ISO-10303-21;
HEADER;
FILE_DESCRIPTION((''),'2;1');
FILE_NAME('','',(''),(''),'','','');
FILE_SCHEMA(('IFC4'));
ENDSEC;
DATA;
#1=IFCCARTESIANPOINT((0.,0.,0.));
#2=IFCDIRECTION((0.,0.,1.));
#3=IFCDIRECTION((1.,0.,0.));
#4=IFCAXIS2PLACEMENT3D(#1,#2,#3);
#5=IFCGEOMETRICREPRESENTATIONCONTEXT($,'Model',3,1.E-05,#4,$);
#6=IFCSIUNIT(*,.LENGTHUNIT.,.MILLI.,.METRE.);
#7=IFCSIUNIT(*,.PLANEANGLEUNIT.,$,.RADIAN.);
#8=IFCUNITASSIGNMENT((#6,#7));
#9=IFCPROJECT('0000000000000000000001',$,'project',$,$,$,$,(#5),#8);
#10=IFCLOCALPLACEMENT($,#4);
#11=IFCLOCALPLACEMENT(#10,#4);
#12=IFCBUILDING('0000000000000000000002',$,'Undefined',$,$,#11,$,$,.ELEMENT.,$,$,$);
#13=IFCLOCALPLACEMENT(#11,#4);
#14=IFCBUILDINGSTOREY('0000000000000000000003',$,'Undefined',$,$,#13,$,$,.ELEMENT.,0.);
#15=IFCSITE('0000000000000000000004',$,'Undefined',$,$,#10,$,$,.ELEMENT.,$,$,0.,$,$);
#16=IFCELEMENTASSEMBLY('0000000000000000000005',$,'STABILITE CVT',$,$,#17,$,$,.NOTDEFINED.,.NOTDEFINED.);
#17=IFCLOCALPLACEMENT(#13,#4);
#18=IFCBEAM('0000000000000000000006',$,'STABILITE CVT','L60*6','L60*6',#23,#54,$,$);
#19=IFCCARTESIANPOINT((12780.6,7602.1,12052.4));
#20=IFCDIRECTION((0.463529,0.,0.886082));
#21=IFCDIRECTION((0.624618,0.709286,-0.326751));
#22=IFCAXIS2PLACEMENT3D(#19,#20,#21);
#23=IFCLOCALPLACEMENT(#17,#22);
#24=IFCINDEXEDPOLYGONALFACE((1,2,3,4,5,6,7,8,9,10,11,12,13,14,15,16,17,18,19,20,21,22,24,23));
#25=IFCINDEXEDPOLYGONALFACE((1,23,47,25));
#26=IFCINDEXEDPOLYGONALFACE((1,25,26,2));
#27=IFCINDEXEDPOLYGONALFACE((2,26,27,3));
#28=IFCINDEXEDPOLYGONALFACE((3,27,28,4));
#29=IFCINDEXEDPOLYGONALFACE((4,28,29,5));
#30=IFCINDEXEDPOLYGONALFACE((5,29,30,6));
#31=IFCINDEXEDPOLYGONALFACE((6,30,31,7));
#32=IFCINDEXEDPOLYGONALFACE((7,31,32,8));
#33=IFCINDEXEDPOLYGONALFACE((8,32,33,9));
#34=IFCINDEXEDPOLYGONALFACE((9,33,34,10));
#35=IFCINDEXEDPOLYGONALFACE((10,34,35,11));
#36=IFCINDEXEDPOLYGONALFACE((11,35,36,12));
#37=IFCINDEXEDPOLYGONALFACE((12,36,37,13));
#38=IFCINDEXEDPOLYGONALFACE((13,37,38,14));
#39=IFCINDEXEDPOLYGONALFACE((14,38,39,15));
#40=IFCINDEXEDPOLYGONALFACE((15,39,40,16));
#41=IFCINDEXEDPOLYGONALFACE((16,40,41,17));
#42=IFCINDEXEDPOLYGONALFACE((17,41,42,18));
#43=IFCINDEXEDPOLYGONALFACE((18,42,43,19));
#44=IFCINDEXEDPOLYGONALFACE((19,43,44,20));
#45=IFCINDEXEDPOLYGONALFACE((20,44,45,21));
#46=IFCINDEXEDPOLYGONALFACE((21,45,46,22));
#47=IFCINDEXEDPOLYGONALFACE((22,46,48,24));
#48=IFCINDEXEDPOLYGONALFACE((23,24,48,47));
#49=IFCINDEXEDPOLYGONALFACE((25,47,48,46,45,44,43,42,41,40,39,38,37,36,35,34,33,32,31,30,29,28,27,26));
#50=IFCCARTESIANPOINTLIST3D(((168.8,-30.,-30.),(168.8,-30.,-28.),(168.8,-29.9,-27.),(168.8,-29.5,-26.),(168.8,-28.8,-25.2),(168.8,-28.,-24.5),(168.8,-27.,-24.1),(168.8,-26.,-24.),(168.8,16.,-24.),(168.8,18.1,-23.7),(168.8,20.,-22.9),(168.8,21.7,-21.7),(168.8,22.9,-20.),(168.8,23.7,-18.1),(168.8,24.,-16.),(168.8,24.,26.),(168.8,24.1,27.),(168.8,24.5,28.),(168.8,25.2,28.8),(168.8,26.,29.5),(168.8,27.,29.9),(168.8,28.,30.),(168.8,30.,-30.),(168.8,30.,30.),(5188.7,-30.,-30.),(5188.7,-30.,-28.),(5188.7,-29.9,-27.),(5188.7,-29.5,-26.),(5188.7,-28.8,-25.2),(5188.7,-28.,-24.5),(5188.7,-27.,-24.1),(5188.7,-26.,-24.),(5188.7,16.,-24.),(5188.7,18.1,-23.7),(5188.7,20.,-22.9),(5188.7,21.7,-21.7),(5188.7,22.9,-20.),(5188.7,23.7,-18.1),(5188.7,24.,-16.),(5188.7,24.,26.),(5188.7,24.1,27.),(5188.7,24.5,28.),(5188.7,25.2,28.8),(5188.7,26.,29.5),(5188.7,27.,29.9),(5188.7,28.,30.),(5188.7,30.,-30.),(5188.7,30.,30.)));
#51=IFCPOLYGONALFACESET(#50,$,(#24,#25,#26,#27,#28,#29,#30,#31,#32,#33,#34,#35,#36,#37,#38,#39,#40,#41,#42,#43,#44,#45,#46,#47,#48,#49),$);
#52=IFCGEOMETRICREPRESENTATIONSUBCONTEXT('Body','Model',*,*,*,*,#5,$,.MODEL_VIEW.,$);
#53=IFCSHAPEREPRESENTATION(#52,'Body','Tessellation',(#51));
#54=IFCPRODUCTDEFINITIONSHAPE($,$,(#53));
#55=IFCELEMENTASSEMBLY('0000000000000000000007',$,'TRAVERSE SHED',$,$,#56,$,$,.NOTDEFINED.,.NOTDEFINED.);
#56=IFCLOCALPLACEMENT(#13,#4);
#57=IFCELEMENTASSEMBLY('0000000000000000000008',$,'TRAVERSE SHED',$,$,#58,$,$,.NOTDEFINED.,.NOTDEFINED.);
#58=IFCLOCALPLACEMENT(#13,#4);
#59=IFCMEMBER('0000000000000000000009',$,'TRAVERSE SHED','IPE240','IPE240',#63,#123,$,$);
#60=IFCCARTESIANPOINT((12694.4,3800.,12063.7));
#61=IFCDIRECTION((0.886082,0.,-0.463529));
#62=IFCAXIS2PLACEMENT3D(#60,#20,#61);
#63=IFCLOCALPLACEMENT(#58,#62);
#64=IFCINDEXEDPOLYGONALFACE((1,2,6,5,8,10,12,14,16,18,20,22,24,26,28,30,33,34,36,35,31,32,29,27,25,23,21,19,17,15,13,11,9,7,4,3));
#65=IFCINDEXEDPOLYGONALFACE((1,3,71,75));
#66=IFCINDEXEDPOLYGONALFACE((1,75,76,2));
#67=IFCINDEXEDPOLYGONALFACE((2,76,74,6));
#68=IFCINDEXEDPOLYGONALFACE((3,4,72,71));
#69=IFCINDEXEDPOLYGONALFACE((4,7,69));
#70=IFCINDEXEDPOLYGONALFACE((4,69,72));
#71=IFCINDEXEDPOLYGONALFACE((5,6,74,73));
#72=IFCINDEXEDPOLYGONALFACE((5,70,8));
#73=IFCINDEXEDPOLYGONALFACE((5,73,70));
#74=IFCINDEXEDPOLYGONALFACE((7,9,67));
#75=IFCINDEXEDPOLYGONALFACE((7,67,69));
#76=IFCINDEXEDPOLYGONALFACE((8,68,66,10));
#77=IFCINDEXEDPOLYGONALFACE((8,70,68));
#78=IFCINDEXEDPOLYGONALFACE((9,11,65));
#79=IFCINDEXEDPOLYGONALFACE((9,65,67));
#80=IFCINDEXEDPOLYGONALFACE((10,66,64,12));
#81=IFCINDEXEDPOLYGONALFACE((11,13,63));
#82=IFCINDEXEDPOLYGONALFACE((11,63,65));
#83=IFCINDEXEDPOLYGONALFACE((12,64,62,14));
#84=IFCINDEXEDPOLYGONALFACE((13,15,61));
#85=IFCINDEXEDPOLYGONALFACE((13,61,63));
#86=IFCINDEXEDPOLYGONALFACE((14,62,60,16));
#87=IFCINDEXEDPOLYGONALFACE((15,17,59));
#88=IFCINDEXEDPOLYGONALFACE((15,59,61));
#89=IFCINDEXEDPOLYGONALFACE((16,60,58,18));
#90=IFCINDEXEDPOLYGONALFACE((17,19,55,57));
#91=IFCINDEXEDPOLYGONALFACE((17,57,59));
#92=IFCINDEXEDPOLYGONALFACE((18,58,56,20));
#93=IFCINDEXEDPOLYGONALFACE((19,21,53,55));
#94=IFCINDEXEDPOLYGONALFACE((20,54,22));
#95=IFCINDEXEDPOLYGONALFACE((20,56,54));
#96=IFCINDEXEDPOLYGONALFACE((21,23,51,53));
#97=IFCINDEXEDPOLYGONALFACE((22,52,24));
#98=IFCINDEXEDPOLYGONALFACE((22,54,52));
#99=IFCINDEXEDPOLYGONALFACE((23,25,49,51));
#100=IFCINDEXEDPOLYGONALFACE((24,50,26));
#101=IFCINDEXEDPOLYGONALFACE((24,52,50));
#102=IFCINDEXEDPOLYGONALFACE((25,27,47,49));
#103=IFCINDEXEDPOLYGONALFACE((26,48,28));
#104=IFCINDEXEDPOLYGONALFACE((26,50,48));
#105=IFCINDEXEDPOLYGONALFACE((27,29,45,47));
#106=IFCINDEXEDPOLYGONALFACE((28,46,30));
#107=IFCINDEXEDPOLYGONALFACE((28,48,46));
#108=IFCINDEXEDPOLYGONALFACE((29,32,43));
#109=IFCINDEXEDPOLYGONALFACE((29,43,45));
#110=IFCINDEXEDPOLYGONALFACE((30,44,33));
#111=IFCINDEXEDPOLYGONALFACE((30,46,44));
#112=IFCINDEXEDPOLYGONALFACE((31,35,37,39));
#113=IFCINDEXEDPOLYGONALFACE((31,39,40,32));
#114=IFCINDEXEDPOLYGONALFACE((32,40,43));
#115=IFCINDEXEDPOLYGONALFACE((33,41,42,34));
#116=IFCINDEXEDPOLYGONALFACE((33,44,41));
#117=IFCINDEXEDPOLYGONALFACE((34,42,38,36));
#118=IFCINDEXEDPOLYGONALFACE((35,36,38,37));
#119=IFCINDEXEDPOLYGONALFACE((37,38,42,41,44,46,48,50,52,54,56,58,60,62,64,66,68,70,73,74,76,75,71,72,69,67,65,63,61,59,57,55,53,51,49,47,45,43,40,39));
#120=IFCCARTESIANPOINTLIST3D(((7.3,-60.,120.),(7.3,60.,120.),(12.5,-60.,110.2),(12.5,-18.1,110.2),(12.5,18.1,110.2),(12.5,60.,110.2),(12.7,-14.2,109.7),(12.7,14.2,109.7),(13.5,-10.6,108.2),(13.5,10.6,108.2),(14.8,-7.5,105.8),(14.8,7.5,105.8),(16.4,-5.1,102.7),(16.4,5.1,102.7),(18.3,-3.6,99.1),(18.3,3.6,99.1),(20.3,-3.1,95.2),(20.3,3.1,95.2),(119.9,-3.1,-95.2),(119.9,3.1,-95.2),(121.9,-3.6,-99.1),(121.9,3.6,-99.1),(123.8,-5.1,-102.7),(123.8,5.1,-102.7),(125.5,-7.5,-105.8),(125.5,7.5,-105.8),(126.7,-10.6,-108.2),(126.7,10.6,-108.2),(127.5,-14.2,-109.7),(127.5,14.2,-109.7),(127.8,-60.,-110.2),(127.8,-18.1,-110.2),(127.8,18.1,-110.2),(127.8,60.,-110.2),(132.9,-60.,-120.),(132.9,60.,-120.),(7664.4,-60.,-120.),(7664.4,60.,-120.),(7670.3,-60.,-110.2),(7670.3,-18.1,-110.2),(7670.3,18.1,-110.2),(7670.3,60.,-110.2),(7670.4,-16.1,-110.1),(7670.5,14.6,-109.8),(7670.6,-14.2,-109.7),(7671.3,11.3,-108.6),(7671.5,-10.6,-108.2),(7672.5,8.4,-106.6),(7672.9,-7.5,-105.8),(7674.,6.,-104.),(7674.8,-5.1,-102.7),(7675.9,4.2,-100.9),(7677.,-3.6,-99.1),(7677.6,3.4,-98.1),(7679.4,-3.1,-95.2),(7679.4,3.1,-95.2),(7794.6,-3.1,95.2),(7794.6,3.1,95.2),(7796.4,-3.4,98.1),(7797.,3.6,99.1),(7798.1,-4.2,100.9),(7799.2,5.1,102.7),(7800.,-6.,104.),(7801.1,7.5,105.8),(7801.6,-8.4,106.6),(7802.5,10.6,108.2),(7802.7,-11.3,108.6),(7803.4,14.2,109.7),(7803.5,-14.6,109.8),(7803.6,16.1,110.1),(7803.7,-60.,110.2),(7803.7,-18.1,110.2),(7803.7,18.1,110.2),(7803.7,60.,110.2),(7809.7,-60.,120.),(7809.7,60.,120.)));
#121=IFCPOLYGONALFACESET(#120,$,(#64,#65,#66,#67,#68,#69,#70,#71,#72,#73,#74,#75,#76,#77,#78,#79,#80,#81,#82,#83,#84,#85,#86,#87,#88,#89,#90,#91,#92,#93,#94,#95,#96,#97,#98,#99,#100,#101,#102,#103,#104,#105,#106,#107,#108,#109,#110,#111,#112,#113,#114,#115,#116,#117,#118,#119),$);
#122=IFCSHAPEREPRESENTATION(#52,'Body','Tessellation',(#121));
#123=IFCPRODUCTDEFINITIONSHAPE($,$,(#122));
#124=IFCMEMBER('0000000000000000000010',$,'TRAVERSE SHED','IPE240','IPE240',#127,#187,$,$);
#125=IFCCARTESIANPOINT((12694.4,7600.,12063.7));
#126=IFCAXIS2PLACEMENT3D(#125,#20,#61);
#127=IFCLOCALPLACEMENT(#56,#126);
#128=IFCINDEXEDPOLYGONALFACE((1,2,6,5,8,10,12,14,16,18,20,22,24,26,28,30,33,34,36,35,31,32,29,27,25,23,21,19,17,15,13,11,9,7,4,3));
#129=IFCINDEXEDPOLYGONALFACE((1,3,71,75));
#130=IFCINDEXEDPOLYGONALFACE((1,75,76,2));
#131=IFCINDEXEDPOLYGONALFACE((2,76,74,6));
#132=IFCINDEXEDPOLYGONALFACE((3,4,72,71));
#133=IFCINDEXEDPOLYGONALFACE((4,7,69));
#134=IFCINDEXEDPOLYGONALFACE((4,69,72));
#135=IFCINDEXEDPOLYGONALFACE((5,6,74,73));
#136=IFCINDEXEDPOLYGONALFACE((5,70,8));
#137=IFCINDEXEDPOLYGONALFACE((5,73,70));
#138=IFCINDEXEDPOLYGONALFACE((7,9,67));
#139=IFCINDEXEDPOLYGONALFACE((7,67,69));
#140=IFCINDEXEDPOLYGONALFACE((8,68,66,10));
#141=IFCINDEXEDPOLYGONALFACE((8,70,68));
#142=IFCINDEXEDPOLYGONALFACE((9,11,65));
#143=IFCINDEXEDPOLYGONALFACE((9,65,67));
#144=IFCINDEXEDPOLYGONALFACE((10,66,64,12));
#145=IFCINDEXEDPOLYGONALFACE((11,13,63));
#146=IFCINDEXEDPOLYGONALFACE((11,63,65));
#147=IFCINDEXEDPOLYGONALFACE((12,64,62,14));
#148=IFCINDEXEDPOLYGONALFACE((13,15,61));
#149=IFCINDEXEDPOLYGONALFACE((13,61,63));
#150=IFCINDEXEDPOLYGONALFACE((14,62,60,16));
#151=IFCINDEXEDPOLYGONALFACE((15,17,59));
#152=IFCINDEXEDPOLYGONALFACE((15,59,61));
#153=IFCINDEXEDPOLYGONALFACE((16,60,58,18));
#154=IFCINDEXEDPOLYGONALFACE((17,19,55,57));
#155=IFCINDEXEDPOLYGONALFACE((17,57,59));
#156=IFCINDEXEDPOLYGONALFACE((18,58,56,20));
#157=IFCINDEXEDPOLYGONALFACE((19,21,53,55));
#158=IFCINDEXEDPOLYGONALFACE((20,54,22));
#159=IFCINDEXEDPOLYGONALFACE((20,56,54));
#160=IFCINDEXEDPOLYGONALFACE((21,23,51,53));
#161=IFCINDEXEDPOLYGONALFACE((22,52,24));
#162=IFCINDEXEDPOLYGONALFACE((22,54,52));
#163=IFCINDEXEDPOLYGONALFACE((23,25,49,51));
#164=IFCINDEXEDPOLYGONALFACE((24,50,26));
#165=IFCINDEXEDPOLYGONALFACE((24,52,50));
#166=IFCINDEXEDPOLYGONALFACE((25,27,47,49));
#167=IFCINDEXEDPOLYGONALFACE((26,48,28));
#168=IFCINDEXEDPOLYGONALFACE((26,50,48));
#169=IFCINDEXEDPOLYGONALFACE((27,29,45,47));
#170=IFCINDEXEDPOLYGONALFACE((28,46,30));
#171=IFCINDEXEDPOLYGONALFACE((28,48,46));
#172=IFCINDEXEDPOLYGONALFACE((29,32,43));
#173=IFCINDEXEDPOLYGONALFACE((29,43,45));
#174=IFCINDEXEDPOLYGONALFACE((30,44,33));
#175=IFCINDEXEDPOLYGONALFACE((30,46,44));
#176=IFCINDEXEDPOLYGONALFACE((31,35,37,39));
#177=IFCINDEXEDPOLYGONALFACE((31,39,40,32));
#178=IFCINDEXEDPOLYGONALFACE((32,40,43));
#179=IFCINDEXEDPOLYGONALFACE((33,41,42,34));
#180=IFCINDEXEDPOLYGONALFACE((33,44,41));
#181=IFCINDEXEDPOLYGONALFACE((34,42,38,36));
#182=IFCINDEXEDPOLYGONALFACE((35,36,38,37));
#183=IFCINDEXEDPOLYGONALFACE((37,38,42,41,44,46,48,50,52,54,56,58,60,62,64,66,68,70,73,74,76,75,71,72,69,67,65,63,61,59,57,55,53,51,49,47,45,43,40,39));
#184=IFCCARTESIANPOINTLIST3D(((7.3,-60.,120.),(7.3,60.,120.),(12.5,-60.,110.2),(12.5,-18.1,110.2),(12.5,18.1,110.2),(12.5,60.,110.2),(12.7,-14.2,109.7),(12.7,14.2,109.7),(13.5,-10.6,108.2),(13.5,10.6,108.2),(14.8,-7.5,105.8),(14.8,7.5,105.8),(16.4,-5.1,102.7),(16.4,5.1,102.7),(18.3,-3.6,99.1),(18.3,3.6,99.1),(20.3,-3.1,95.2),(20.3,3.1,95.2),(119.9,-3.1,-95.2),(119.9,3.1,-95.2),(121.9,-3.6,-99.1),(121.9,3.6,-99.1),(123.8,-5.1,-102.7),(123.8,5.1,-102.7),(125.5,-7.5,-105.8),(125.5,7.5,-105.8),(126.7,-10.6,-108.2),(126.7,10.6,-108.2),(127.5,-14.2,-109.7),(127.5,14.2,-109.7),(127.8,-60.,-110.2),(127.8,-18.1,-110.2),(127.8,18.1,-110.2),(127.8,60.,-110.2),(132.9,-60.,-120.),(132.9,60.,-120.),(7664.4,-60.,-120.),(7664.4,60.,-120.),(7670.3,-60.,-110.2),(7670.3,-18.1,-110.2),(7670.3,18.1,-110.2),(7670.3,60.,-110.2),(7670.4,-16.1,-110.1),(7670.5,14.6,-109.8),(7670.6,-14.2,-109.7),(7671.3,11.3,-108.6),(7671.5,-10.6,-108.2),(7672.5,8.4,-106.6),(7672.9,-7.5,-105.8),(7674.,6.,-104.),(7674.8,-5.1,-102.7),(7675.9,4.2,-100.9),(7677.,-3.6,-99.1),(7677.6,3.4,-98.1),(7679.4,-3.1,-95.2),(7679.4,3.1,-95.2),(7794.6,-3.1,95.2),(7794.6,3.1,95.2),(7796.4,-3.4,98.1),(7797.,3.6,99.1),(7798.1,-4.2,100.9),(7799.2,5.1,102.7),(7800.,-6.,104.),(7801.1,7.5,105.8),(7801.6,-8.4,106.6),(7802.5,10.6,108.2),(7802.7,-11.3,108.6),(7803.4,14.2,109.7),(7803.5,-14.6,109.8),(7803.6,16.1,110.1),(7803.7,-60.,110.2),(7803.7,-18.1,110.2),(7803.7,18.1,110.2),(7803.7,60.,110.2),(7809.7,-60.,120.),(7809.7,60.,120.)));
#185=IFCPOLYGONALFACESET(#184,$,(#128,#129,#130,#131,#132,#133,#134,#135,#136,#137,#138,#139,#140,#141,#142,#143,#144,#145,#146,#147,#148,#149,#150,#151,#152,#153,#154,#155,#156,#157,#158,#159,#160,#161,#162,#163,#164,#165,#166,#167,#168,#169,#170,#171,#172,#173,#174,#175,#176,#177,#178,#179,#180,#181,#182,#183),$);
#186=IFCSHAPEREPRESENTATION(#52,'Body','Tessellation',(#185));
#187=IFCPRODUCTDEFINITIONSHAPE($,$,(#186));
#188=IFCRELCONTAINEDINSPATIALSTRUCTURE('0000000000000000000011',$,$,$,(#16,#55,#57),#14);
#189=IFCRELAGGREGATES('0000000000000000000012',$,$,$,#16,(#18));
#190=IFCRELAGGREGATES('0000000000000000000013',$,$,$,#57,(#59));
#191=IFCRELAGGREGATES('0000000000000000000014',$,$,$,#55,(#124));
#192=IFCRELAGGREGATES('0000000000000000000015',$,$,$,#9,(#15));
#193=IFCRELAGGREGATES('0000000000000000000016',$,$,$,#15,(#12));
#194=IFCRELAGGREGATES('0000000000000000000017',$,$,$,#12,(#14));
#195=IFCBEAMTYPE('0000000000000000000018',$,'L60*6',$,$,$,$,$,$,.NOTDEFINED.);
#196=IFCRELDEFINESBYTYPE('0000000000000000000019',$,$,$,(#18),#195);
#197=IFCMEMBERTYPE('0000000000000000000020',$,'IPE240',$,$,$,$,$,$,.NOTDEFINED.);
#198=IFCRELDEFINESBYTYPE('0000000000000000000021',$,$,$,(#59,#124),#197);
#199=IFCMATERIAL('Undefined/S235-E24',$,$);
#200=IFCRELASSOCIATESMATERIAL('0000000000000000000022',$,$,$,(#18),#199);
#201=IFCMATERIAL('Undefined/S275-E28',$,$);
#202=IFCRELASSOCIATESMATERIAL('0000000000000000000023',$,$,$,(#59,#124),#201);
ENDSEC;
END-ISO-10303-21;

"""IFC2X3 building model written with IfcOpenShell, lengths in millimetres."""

from ifc_helpers import new_model, si_unit, frame, origin_with_axes, origin_2d_with_axis, place, context, subcontext, project, spatial, i_section, l_section, extrude, clip, halfspace, material, type_object, element, aggregate, save


model = new_model("IFC2X3")

# Units and contexts
model_context = context("Model", 3, precision=1e-05, world=origin_with_axes())
body_context = subcontext(model_context, "Body", "Model", "MODEL_VIEW")
ifc_project = project(units=[si_unit("LENGTHUNIT", "METRE", prefix="MILLI"), si_unit("PLANEANGLEUNIT", "RADIAN")], contexts=[model_context])

# Site, building, storey
site_placement = place(None, origin_with_axes())
site = spatial("IfcSite", under=ifc_project, at=site_placement, Name="Undefined", CompositionType="ELEMENT", RefElevation=0.0)
building_placement = place(site_placement, origin_with_axes())
building = spatial("IfcBuilding", under=site, at=building_placement, Name="Undefined", CompositionType="ELEMENT")
storey_placement = place(building_placement, origin_with_axes())
storey = spatial("IfcBuildingStorey", under=building, at=storey_placement, Name="Undefined", CompositionType="ELEMENT", Elevation=0.0)

# Element assembly, beam
assembly_1_placement = place(storey_placement, origin_with_axes())
assembly_1 = element("IfcElementAssembly", 1, at=assembly_1_placement, inside=storey, Name="STABILITE CVT", AssemblyPlace="NOTDEFINED", PredefinedType="NOTDEFINED")
ifc_material_1 = material(Name="Undefined/S235-E24")
beam_type_1 = type_object("IfcBeamType", Name="L60*6", PredefinedType="NOTDEFINED")
beam_1_placement = place(assembly_1_placement, frame((12780.6, 7602.1, 12052.4), z_axis=(0.463529, 0.0, 0.886082), x_axis=(0.624618, 0.709286, -0.326751)))
beam_1 = element("IfcBeam", 2, at=beam_1_placement, type_object=beam_type_1, material=ifc_material_1, Name="STABILITE CVT", Description="L60*6", ObjectType="L60*6", context=body_context, shape_type="Clipping", body=[
    clip(clip(extrude(l_section(Depth=60.0, Width=60.0, Thickness=6.0, FilletRadius=8.0, EdgeRadius=4.0, at=origin_2d_with_axis()), frame((5268.6, 0.0, 0.0), z_axis=(-1.0, 0.0, 0.0), x_axis=(0.0, -1.0, 0.0)), (0.0, 0.0, 1.0), 5179.7), halfspace(frame((5188.7, 30.0, -30.0), z_axis=(-1.0, 0.0, 0.0), x_axis=(0.0, 0.0, 1.0)), True)), halfspace(frame((168.8, -30.0, -30.0), z_axis=(1.0, 0.0, 0.0), x_axis=(0.0, 0.0, 1.0)), True)),
])
aggregate(assembly_1, [beam_1])

# Element assemblies
assembly_2_placement = place(storey_placement, origin_with_axes())
assembly_2 = element("IfcElementAssembly", 3, at=assembly_2_placement, inside=storey, Name="TRAVERSE SHED", AssemblyPlace="NOTDEFINED", PredefinedType="NOTDEFINED")
assembly_3_placement = place(storey_placement, origin_with_axes())
assembly_3 = element("IfcElementAssembly", 4, at=assembly_3_placement, inside=storey, Name="TRAVERSE SHED", AssemblyPlace="NOTDEFINED", PredefinedType="NOTDEFINED")
ifc_material_2 = material(Name="Undefined/S275-E28")

# Members
member_type_1 = type_object("IfcMemberType", Name="IPE240", PredefinedType="NOTDEFINED")
member_1_placement = place(assembly_3_placement, frame((12694.4, 3800.0, 12063.7), z_axis=(0.463529, 0.0, 0.886082), x_axis=(0.886082, 0.0, -0.463529)))
member_1 = element("IfcMember", 5, at=member_1_placement, type_object=member_type_1, material=ifc_material_2, Name="TRAVERSE SHED", Description="IPE240", ObjectType="IPE240", context=body_context, shape_type="Clipping", body=[
    clip(clip(extrude(i_section(OverallWidth=120.0, OverallDepth=240.0, WebThickness=6.2, FlangeThickness=9.8, FilletRadius=15.0, at=origin_2d_with_axis()), frame((7941.8, 0.0, 0.0), z_axis=(-1.0, 0.0, 0.0), x_axis=(0.0, -1.0, 0.0)), (0.0, 0.0, 1.0), 8076.5), halfspace(frame((7809.7, 0.0, 120.0), z_axis=(-0.855432, 0.0, 0.517915), x_axis=(0.0, -1.0, 0.0)), True)), halfspace(frame((5.8, 0.0, 123.0), z_axis=(-0.886082, 0.0, -0.463528), x_axis=(0.0, -1.0, 0.0)), False)),
])
aggregate(assembly_3, [member_1])
member_2_placement = place(assembly_2_placement, frame((12694.4, 7600.0, 12063.7), z_axis=(0.463529, 0.0, 0.886082), x_axis=(0.886082, 0.0, -0.463529)))
member_2 = element("IfcMember", 6, at=member_2_placement, type_object=member_type_1, material=ifc_material_2, Name="TRAVERSE SHED", Description="IPE240", ObjectType="IPE240", context=body_context, shape_type="Clipping", body=[
    clip(clip(extrude(i_section(OverallWidth=120.0, OverallDepth=240.0, WebThickness=6.2, FlangeThickness=9.8, FilletRadius=15.0, at=origin_2d_with_axis()), frame((7941.8, 0.0, 0.0), z_axis=(-1.0, 0.0, 0.0), x_axis=(0.0, -1.0, 0.0)), (0.0, 0.0, 1.0), 8076.5), halfspace(frame((7809.7, -3800.0, 120.0), z_axis=(-0.855432, 0.0, 0.517915), x_axis=(0.0, -1.0, 0.0)), True)), halfspace(frame((5.8, 0.0, 123.0), z_axis=(-0.886082, 0.0, -0.463528), x_axis=(0.0, -1.0, 0.0)), False)),
])
aggregate(assembly_2, [member_2])

save(model, "model.ifc")
